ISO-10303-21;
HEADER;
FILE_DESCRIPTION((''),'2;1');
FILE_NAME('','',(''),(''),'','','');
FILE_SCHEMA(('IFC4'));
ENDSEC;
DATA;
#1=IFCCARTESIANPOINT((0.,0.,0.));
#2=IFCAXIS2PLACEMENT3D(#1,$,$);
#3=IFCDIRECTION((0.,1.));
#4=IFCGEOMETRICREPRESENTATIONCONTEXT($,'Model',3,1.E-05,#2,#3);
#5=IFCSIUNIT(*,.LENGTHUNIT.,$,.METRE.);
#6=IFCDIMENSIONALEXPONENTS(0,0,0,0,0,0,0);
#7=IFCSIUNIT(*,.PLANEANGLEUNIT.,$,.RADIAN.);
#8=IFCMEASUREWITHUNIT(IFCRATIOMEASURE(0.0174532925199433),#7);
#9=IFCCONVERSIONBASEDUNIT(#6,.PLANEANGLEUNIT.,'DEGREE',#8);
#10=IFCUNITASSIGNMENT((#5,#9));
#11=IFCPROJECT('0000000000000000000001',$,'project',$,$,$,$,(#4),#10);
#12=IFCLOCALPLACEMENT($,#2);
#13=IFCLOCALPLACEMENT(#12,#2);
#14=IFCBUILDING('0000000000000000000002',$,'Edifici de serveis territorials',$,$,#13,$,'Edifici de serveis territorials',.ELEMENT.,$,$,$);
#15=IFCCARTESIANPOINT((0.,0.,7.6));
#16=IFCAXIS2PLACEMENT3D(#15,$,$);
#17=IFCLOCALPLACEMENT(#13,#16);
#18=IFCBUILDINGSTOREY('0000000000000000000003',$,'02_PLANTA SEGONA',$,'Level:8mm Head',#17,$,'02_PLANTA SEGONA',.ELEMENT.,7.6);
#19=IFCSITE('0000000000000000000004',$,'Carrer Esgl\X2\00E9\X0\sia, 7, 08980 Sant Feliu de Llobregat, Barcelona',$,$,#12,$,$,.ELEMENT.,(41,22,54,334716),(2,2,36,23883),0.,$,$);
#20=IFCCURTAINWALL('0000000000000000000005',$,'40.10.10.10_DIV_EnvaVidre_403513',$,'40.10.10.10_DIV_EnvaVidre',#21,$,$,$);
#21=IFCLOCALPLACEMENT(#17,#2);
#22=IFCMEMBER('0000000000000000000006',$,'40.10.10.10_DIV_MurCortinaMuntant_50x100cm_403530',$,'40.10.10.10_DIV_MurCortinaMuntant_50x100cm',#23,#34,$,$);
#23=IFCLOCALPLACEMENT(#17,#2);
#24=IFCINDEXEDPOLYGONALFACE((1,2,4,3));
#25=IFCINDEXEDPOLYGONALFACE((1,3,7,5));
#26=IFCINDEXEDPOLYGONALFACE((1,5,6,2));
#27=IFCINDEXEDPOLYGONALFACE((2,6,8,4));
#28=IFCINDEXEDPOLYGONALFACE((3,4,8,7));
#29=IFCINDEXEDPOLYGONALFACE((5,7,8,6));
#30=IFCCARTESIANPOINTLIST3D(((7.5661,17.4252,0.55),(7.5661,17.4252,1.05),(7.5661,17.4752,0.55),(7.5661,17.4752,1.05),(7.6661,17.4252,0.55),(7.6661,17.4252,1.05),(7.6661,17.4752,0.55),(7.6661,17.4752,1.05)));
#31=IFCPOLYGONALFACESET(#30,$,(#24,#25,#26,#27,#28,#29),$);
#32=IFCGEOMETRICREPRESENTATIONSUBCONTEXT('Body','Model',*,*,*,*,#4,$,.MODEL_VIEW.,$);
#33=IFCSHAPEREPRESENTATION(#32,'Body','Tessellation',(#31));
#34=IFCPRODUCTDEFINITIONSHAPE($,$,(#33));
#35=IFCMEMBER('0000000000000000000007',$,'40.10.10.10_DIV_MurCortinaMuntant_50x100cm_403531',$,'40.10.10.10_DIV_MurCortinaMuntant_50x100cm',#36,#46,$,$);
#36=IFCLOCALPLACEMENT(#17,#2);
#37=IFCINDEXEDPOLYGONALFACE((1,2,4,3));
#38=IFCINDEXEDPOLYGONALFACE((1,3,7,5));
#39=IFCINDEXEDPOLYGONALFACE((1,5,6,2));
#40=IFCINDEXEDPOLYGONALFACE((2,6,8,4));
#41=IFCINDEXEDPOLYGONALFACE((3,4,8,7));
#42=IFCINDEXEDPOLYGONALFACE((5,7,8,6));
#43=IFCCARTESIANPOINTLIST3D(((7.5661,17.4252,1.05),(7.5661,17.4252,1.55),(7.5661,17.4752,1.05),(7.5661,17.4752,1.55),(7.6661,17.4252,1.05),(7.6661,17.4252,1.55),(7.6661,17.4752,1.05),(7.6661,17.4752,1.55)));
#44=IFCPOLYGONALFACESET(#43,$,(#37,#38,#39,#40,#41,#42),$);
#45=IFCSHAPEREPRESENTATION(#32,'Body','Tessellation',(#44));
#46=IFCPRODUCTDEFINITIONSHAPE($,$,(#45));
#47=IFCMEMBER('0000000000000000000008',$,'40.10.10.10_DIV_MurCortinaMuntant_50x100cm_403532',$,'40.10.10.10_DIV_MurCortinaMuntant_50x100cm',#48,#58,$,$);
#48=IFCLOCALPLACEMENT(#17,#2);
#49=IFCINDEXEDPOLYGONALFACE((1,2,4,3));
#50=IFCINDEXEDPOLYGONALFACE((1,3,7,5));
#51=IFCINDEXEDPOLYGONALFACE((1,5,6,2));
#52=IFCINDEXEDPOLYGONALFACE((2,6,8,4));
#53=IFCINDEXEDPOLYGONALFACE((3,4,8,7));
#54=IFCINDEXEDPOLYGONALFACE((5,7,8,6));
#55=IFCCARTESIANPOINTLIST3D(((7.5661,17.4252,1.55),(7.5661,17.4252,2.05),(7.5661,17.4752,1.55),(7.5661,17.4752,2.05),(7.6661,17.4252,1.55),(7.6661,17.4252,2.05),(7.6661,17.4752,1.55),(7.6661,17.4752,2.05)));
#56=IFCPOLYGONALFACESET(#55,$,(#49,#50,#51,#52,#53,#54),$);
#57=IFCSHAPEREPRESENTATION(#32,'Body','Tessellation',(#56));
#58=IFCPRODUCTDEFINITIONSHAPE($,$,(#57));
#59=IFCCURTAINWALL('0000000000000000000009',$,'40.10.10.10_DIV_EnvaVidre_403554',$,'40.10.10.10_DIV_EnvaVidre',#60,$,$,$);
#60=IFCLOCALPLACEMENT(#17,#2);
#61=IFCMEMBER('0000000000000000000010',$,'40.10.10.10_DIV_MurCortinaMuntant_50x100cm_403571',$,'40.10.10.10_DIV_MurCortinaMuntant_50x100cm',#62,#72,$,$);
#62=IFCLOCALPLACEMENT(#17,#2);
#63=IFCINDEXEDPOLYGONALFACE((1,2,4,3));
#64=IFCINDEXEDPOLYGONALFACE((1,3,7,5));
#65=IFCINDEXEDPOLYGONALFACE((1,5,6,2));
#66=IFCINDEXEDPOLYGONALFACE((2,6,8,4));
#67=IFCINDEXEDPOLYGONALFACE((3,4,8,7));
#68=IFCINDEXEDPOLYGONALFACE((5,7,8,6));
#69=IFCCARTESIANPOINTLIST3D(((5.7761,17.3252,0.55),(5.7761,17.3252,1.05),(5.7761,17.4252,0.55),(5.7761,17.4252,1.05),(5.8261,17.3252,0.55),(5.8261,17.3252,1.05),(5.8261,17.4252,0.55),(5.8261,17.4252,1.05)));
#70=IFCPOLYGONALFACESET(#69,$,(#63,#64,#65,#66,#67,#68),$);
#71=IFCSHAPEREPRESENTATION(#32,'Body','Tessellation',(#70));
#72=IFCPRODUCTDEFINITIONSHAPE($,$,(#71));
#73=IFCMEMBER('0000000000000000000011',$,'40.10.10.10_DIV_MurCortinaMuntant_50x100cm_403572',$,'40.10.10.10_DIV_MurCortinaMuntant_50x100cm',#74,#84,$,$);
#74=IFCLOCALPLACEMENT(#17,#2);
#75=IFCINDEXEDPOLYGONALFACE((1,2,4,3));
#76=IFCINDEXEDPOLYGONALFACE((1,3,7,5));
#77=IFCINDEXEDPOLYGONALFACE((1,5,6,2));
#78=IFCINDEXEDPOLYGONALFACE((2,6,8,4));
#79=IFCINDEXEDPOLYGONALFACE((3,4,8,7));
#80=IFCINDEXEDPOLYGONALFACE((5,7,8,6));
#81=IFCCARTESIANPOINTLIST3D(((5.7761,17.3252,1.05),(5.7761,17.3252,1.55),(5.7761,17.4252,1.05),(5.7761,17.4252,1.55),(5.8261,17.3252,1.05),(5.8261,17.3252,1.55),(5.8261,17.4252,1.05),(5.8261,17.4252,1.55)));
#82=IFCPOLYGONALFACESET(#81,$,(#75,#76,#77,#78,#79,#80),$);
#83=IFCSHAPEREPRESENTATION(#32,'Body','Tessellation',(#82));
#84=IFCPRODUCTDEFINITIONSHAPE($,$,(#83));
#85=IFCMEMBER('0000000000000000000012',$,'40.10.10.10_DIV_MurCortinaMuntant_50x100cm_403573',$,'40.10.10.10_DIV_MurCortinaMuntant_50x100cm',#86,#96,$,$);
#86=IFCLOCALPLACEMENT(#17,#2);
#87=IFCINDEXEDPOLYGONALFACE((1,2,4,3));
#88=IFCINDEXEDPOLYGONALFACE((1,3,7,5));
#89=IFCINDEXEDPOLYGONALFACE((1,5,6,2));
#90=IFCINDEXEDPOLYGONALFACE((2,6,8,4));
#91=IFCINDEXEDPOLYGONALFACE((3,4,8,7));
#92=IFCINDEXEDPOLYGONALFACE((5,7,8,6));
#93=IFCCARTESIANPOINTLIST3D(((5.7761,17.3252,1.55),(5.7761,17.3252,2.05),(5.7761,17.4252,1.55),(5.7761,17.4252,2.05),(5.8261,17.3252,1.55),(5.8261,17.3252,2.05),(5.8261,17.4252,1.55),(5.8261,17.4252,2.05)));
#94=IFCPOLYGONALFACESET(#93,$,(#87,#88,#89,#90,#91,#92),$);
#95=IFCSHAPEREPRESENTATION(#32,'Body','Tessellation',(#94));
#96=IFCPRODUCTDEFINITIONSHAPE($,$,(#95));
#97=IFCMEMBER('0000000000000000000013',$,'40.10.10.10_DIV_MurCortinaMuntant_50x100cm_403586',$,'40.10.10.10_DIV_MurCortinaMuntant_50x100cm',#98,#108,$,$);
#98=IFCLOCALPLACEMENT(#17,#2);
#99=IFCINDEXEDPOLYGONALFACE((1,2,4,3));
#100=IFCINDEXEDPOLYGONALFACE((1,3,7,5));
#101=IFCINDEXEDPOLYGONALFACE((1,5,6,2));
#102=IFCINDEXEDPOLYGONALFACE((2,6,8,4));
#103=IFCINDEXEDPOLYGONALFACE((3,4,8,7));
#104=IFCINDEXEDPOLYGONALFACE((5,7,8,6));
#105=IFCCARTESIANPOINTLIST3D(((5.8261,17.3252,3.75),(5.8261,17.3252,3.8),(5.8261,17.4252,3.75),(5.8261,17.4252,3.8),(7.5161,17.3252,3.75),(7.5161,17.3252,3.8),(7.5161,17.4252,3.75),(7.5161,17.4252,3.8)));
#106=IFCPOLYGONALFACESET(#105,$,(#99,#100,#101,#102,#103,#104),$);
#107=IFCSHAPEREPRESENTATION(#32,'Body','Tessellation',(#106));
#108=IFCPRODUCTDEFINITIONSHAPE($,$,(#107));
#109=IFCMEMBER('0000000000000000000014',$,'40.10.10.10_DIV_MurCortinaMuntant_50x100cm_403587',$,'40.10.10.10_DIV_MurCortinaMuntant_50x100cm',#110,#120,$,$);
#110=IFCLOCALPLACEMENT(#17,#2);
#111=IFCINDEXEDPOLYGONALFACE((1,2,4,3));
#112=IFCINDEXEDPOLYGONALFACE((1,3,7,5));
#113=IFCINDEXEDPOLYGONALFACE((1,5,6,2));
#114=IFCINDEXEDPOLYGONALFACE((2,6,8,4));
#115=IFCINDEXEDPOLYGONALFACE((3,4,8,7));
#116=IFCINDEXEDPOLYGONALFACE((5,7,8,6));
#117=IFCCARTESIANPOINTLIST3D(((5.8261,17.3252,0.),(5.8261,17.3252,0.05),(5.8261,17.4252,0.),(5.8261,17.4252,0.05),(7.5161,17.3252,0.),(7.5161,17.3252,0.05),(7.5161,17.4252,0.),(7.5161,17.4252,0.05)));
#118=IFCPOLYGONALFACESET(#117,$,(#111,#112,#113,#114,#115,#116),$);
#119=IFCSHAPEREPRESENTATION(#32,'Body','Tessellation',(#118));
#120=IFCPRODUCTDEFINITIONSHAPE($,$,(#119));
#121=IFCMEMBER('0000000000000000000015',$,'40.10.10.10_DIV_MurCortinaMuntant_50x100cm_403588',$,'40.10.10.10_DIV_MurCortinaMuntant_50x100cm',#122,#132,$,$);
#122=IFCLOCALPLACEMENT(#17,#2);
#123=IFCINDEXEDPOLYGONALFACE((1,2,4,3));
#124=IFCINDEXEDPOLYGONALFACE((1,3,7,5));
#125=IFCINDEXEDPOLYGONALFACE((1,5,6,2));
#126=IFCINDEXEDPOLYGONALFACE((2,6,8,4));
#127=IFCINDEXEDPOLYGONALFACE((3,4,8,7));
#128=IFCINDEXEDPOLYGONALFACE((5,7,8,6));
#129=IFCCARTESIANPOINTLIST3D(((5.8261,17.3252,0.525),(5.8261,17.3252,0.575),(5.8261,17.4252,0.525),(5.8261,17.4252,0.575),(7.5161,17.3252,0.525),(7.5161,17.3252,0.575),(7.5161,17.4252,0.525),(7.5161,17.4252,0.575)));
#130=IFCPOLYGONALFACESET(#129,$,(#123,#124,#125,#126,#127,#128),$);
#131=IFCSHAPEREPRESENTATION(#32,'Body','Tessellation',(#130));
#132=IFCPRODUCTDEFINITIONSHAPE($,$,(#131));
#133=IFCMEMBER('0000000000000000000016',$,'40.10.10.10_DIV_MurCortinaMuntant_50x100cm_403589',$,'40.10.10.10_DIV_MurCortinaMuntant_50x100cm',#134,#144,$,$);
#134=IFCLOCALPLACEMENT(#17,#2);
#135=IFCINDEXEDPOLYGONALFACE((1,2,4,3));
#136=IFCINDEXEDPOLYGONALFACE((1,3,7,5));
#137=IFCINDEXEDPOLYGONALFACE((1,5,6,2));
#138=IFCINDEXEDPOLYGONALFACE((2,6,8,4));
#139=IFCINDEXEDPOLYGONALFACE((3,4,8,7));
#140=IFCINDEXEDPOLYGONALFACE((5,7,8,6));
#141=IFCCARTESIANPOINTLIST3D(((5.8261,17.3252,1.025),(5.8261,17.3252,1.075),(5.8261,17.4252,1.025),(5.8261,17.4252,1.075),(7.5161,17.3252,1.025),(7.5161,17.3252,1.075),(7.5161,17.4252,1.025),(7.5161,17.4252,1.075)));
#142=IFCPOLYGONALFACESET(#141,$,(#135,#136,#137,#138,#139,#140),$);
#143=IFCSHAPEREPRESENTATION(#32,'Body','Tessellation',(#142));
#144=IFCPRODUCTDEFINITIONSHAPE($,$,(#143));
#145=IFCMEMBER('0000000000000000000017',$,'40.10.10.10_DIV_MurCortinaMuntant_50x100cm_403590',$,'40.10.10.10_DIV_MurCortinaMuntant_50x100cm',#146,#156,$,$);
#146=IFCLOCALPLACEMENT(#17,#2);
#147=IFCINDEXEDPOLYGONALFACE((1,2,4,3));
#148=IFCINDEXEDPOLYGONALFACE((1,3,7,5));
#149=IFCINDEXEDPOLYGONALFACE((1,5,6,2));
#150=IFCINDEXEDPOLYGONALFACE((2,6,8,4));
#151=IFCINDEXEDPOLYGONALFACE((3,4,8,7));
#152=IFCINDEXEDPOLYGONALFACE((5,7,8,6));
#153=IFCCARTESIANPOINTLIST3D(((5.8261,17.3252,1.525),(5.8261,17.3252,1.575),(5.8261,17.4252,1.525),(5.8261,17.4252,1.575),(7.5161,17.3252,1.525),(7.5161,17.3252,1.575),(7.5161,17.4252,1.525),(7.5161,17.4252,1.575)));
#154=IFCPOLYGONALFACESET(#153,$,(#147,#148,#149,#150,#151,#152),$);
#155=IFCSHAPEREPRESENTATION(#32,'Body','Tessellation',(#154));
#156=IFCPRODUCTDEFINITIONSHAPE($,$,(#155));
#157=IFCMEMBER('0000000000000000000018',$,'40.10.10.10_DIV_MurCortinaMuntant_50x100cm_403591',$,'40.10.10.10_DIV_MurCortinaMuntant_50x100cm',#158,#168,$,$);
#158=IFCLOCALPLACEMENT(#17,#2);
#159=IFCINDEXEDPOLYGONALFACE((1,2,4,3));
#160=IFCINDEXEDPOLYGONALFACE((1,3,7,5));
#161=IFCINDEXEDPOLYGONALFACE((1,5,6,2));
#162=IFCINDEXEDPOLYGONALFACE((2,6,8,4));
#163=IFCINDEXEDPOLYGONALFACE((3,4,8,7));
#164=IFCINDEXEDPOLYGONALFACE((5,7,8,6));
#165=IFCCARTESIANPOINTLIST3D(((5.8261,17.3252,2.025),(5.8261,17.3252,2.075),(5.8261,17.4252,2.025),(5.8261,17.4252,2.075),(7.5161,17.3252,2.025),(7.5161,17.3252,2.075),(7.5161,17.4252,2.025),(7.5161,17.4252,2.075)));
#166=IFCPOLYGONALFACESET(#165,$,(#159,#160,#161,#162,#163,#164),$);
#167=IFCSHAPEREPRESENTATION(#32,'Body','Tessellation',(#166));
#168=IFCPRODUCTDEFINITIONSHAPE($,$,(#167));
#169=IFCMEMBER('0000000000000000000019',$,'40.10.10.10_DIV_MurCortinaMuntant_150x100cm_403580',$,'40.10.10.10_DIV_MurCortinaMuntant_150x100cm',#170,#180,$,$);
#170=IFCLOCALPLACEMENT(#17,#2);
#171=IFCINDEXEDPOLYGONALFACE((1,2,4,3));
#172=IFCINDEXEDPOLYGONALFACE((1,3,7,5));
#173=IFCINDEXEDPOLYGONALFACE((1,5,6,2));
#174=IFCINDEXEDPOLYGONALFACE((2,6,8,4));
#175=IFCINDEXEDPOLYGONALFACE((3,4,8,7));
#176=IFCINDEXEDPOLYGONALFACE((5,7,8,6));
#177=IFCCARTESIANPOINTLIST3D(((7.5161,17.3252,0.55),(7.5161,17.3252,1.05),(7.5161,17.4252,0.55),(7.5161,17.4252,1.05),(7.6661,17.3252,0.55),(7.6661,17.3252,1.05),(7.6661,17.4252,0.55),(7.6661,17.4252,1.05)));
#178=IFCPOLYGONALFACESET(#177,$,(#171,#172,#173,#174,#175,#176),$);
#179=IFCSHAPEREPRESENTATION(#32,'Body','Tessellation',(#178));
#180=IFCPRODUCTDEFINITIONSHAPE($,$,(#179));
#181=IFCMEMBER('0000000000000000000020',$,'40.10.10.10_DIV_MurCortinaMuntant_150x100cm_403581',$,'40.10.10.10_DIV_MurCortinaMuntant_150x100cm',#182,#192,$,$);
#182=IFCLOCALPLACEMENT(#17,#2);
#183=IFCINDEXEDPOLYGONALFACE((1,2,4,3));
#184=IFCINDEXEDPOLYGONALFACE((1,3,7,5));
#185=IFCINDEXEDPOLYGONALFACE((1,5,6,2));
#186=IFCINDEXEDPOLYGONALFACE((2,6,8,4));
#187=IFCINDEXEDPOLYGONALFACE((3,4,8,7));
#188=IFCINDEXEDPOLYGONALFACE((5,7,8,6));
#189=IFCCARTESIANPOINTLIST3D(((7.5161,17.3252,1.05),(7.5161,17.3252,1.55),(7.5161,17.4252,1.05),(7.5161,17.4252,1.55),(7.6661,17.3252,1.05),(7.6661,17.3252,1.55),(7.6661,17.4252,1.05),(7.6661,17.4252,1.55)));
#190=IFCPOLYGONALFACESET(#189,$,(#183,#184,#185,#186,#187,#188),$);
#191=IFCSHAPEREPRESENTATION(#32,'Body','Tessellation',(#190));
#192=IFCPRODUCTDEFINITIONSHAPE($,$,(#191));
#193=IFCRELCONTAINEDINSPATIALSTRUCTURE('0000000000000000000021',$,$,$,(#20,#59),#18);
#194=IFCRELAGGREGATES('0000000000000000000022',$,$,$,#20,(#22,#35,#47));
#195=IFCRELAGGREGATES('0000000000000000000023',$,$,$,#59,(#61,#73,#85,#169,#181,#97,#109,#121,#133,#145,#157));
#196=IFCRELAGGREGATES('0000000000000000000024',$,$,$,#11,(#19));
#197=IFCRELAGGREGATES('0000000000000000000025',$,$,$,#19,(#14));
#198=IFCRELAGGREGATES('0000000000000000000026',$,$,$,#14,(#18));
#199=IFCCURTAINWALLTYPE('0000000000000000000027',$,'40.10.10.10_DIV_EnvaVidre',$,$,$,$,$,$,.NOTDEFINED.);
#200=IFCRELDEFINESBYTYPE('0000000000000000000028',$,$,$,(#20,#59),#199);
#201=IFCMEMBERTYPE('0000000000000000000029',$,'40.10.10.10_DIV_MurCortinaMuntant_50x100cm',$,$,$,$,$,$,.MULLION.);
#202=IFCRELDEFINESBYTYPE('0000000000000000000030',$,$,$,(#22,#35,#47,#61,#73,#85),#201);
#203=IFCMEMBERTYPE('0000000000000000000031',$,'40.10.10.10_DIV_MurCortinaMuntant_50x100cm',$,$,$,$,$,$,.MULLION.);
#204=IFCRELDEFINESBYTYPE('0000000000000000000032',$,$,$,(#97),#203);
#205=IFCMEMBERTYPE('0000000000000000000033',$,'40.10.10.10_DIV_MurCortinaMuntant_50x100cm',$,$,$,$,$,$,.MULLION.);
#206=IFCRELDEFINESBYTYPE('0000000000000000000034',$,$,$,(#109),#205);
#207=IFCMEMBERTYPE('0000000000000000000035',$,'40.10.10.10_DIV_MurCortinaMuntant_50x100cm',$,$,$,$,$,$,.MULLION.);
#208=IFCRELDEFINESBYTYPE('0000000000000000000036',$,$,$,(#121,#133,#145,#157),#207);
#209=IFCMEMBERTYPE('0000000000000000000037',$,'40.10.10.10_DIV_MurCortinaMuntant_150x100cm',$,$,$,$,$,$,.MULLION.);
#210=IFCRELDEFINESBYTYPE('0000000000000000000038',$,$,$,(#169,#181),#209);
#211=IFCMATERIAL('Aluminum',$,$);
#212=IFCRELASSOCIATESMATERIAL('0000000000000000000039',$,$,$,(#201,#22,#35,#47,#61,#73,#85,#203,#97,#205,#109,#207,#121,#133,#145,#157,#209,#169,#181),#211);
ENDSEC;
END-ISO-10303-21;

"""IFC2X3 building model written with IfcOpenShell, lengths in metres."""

from ifc_helpers import new_model, entity, si_unit, converted_unit, direction, frame, origin, origin_2d_with_axis, place, context, subcontext, project, spatial, rectangle, extrude, source, transform, mapped, material, type_object, type_shapes, element, aggregate, save


model = new_model("IFC2X3")

# Units and contexts
model_context = context("Model", 3, precision=1e-05, world=origin(), true_north=direction((0.0, 1.0)))
body_context = subcontext(model_context, "Body", "Model", "MODEL_VIEW")
ifc_project = project(units=[si_unit("LENGTHUNIT", "METRE"), converted_unit("PLANEANGLEUNIT", "DEGREE", entity("IfcRatioMeasure", 0.0174532925199433), si_unit("PLANEANGLEUNIT", "RADIAN"), dimensions=[0, 0, 0, 0, 0, 0, 0])], contexts=[model_context])

# Site, building, storey
site_placement = place(None, origin())
site = spatial("IfcSite", under=ifc_project, at=site_placement, Name="Carrer Església, 7, 08980 Sant Feliu de Llobregat, Barcelona", CompositionType="ELEMENT", RefLatitude=(41, 22, 54, 334716), RefLongitude=(2, 2, 36, 23883), RefElevation=0.0)
building_placement = place(site_placement, origin())
building = spatial("IfcBuilding", under=site, at=building_placement, Name="Edifici de serveis territorials", LongName="Edifici de serveis territorials", CompositionType="ELEMENT")
storey_placement = place(building_placement, frame((0.0, 0.0, 7.6)))
storey = spatial("IfcBuildingStorey", under=building, at=storey_placement, Name="02_PLANTA SEGONA", ObjectType="Level:8mm Head", LongName="02_PLANTA SEGONA", CompositionType="ELEMENT", Elevation=7.6)

# Curtain walls, members
curtain_wall_type = type_object("IfcCurtainWallType", Name="40.10.10.10_DIV_EnvaVidre", PredefinedType="NOTDEFINED")
curtain_wall_1_placement = place(storey_placement, frame((0.0, 0.0, -7.6)))
curtain_wall_1 = element("IfcCurtainWall", 1, at=curtain_wall_1_placement, inside=storey, type_object=curtain_wall_type, Name="40.10.10.10_DIV_EnvaVidre_403513", ObjectType="40.10.10.10_DIV_EnvaVidre")
ifc_material_1 = material(Name="Aluminum")
member_type_1 = type_object("IfcMemberType", Name="40.10.10.10_DIV_MurCortinaMuntant_50x100cm", PredefinedType="MULLION", material=ifc_material_1)
shared_shape_1 = source(origin(), body_context, "Body", "SweptSolid", [
    extrude(rectangle(XDim=0.1, YDim=0.05, at=origin_2d_with_axis()), frame((-0.025, 0.0, -0.5), z_axis=(0.0, 0.0, 1.0), x_axis=(0.0, -1.0, 0.0)), (0.0, 0.0, 1.0), 0.5),
])
type_shapes(member_type_1, [shared_shape_1])
member_1_placement = place(storey_placement, frame((7.6161, 17.4252, 0.55), z_axis=(0.0, 0.0, -1.0), x_axis=(0.0, -1.0, 0.0)))
member_1 = element("IfcMember", 2, at=member_1_placement, type_object=member_type_1, material=ifc_material_1, Name="40.10.10.10_DIV_MurCortinaMuntant_50x100cm_403530", ObjectType="40.10.10.10_DIV_MurCortinaMuntant_50x100cm", context=body_context, shape_type="MappedRepresentation", body=[
    mapped(shared_shape_1, transform((0.0, 0.0, 0.0), scale=1.0)),
])
member_2_placement = place(storey_placement, frame((7.6161, 17.4252, 1.05), z_axis=(0.0, 0.0, -1.0), x_axis=(0.0, -1.0, 0.0)))
member_2 = element("IfcMember", 3, at=member_2_placement, type_object=member_type_1, material=ifc_material_1, Name="40.10.10.10_DIV_MurCortinaMuntant_50x100cm_403531", ObjectType="40.10.10.10_DIV_MurCortinaMuntant_50x100cm", context=body_context, shape_type="MappedRepresentation", body=[
    mapped(shared_shape_1, transform((0.0, 0.0, 0.0), scale=1.0)),
])
member_3_placement = place(storey_placement, frame((7.6161, 17.4252, 1.55), z_axis=(0.0, 0.0, -1.0), x_axis=(0.0, -1.0, 0.0)))
member_3 = element("IfcMember", 4, at=member_3_placement, type_object=member_type_1, material=ifc_material_1, Name="40.10.10.10_DIV_MurCortinaMuntant_50x100cm_403532", ObjectType="40.10.10.10_DIV_MurCortinaMuntant_50x100cm", context=body_context, shape_type="MappedRepresentation", body=[
    mapped(shared_shape_1, transform((0.0, 0.0, 0.0), scale=1.0)),
])
curtain_wall_2_placement = place(storey_placement, frame((0.0, 0.0, -7.6)))
curtain_wall_2 = element("IfcCurtainWall", 5, at=curtain_wall_2_placement, inside=storey, type_object=curtain_wall_type, Name="40.10.10.10_DIV_EnvaVidre_403554", ObjectType="40.10.10.10_DIV_EnvaVidre")
member_4_placement = place(storey_placement, frame((5.7761, 17.3752, 0.55), z_axis=(0.0, 0.0, -1.0), x_axis=(-1.0, 0.0, 0.0)))
member_4 = element("IfcMember", 6, at=member_4_placement, type_object=member_type_1, material=ifc_material_1, Name="40.10.10.10_DIV_MurCortinaMuntant_50x100cm_403571", ObjectType="40.10.10.10_DIV_MurCortinaMuntant_50x100cm", context=body_context, shape_type="MappedRepresentation", body=[
    mapped(shared_shape_1, transform((0.0, 0.0, 0.0), scale=1.0)),
])
member_5_placement = place(storey_placement, frame((5.7761, 17.3752, 1.05), z_axis=(0.0, 0.0, -1.0), x_axis=(-1.0, 0.0, 0.0)))
member_5 = element("IfcMember", 7, at=member_5_placement, type_object=member_type_1, material=ifc_material_1, Name="40.10.10.10_DIV_MurCortinaMuntant_50x100cm_403572", ObjectType="40.10.10.10_DIV_MurCortinaMuntant_50x100cm", context=body_context, shape_type="MappedRepresentation", body=[
    mapped(shared_shape_1, transform((0.0, 0.0, 0.0), scale=1.0)),
])
member_6_placement = place(storey_placement, frame((5.7761, 17.3752, 1.55), z_axis=(0.0, 0.0, -1.0), x_axis=(-1.0, 0.0, 0.0)))
member_6 = element("IfcMember", 8, at=member_6_placement, type_object=member_type_1, material=ifc_material_1, Name="40.10.10.10_DIV_MurCortinaMuntant_50x100cm_403573", ObjectType="40.10.10.10_DIV_MurCortinaMuntant_50x100cm", context=body_context, shape_type="MappedRepresentation", body=[
    mapped(shared_shape_1, transform((0.0, 0.0, 0.0), scale=1.0)),
])
member_type_2 = type_object("IfcMemberType", Name="40.10.10.10_DIV_MurCortinaMuntant_50x100cm", PredefinedType="MULLION", material=ifc_material_1)
shared_shape_2 = source(origin(), body_context, "Body", "SweptSolid", [
    extrude(rectangle(XDim=0.1, YDim=0.05, at=origin_2d_with_axis()), frame((-0.025, 0.0, -1.69), z_axis=(0.0, 0.0, 1.0), x_axis=(0.0, -1.0, 0.0)), (0.0, 0.0, 1.0), 1.69),
])
type_shapes(member_type_2, [shared_shape_2])
member_7_placement = place(storey_placement, frame((5.8261, 17.3752, 3.8), z_axis=(-1.0, 0.0, 0.0), x_axis=(0.0, 0.0, 1.0)))
member_7 = element("IfcMember", 9, at=member_7_placement, type_object=member_type_2, material=ifc_material_1, Name="40.10.10.10_DIV_MurCortinaMuntant_50x100cm_403586", ObjectType="40.10.10.10_DIV_MurCortinaMuntant_50x100cm", context=body_context, shape_type="MappedRepresentation", body=[
    mapped(shared_shape_2, transform((0.0, 0.0, 0.0), scale=1.0)),
])
member_type_3 = type_object("IfcMemberType", Name="40.10.10.10_DIV_MurCortinaMuntant_50x100cm", PredefinedType="MULLION", material=ifc_material_1)
shared_shape_3 = source(origin(), body_context, "Body", "SweptSolid", [
    extrude(rectangle(XDim=0.1, YDim=0.05, at=origin_2d_with_axis()), frame((-0.025, 0.0, -1.69), z_axis=(0.0, 0.0, 1.0), x_axis=(0.0, -1.0, 0.0)), (0.0, 0.0, 1.0), 1.69),
])
type_shapes(member_type_3, [shared_shape_3])
member_8_placement = place(storey_placement, frame((7.5161, 17.3752, 0.0), z_axis=(1.0, 0.0, 0.0), x_axis=(0.0, 0.0, -1.0)))
member_8 = element("IfcMember", 10, at=member_8_placement, type_object=member_type_3, material=ifc_material_1, Name="40.10.10.10_DIV_MurCortinaMuntant_50x100cm_403587", ObjectType="40.10.10.10_DIV_MurCortinaMuntant_50x100cm", context=body_context, shape_type="MappedRepresentation", body=[
    mapped(shared_shape_3, transform((0.0, 0.0, 0.0), scale=1.0)),
])
member_type_4 = type_object("IfcMemberType", Name="40.10.10.10_DIV_MurCortinaMuntant_50x100cm", PredefinedType="MULLION", material=ifc_material_1)
shared_shape_4 = source(origin(), body_context, "Body", "SweptSolid", [
    extrude(rectangle(XDim=0.1, YDim=0.05, at=origin_2d_with_axis()), frame((0.0, 0.0, -1.69), z_axis=(0.0, 0.0, 1.0), x_axis=(0.0, -1.0, 0.0)), (0.0, 0.0, 1.0), 1.69),
])
type_shapes(member_type_4, [shared_shape_4])
member_9_placement = place(storey_placement, frame((5.8261, 17.3752, 0.55), z_axis=(-1.0, 0.0, 0.0), x_axis=(0.0, 0.0, 1.0)))
member_9 = element("IfcMember", 11, at=member_9_placement, type_object=member_type_4, material=ifc_material_1, Name="40.10.10.10_DIV_MurCortinaMuntant_50x100cm_403588", ObjectType="40.10.10.10_DIV_MurCortinaMuntant_50x100cm", context=body_context, shape_type="MappedRepresentation", body=[
    mapped(shared_shape_4, transform((0.0, 0.0, 0.0), scale=1.0)),
])
member_10_placement = place(storey_placement, frame((5.8261, 17.3752, 1.05), z_axis=(-1.0, 0.0, 0.0), x_axis=(0.0, 0.0, 1.0)))
member_10 = element("IfcMember", 12, at=member_10_placement, type_object=member_type_4, material=ifc_material_1, Name="40.10.10.10_DIV_MurCortinaMuntant_50x100cm_403589", ObjectType="40.10.10.10_DIV_MurCortinaMuntant_50x100cm", context=body_context, shape_type="MappedRepresentation", body=[
    mapped(shared_shape_4, transform((0.0, 0.0, 0.0), scale=1.0)),
])
member_11_placement = place(storey_placement, frame((5.8261, 17.3752, 1.55), z_axis=(-1.0, 0.0, 0.0), x_axis=(0.0, 0.0, 1.0)))
member_11 = element("IfcMember", 13, at=member_11_placement, type_object=member_type_4, material=ifc_material_1, Name="40.10.10.10_DIV_MurCortinaMuntant_50x100cm_403590", ObjectType="40.10.10.10_DIV_MurCortinaMuntant_50x100cm", context=body_context, shape_type="MappedRepresentation", body=[
    mapped(shared_shape_4, transform((0.0, 0.0, 0.0), scale=1.0)),
])
member_12_placement = place(storey_placement, frame((5.8261, 17.3752, 2.05), z_axis=(-1.0, 0.0, 0.0), x_axis=(0.0, 0.0, 1.0)))
member_12 = element("IfcMember", 14, at=member_12_placement, type_object=member_type_4, material=ifc_material_1, Name="40.10.10.10_DIV_MurCortinaMuntant_50x100cm_403591", ObjectType="40.10.10.10_DIV_MurCortinaMuntant_50x100cm", context=body_context, shape_type="MappedRepresentation", body=[
    mapped(shared_shape_4, transform((0.0, 0.0, 0.0), scale=1.0)),
])
member_type_5 = type_object("IfcMemberType", Name="40.10.10.10_DIV_MurCortinaMuntant_150x100cm", PredefinedType="MULLION", material=ifc_material_1)
shared_shape_5 = source(origin(), body_context, "Body", "SweptSolid", [
    extrude(rectangle(XDim=0.1, YDim=0.15, at=origin_2d_with_axis()), frame((-0.075, 0.0, -0.5), z_axis=(0.0, 0.0, 1.0), x_axis=(0.0, -1.0, 0.0)), (0.0, 0.0, 1.0), 0.5),
])
type_shapes(member_type_5, [shared_shape_5])
member_13_placement = place(storey_placement, frame((7.6661, 17.3752, 1.05)))
member_13 = element("IfcMember", 15, at=member_13_placement, type_object=member_type_5, material=ifc_material_1, Name="40.10.10.10_DIV_MurCortinaMuntant_150x100cm_403580", ObjectType="40.10.10.10_DIV_MurCortinaMuntant_150x100cm", context=body_context, shape_type="MappedRepresentation", body=[
    mapped(shared_shape_5, transform((0.0, 0.0, 0.0), scale=1.0)),
])
member_14_placement = place(storey_placement, frame((7.6661, 17.3752, 1.55)))
member_14 = element("IfcMember", 16, at=member_14_placement, type_object=member_type_5, material=ifc_material_1, Name="40.10.10.10_DIV_MurCortinaMuntant_150x100cm_403581", ObjectType="40.10.10.10_DIV_MurCortinaMuntant_150x100cm", context=body_context, shape_type="MappedRepresentation", body=[
    mapped(shared_shape_5, transform((0.0, 0.0, 0.0), scale=1.0)),
])

aggregate(curtain_wall_1, [member_1, member_2, member_3])

aggregate(curtain_wall_2, [member_4, member_5, member_6, member_13, member_14, member_7, member_8, member_9, member_10, member_11, member_12])

save(model, "model.ifc")
